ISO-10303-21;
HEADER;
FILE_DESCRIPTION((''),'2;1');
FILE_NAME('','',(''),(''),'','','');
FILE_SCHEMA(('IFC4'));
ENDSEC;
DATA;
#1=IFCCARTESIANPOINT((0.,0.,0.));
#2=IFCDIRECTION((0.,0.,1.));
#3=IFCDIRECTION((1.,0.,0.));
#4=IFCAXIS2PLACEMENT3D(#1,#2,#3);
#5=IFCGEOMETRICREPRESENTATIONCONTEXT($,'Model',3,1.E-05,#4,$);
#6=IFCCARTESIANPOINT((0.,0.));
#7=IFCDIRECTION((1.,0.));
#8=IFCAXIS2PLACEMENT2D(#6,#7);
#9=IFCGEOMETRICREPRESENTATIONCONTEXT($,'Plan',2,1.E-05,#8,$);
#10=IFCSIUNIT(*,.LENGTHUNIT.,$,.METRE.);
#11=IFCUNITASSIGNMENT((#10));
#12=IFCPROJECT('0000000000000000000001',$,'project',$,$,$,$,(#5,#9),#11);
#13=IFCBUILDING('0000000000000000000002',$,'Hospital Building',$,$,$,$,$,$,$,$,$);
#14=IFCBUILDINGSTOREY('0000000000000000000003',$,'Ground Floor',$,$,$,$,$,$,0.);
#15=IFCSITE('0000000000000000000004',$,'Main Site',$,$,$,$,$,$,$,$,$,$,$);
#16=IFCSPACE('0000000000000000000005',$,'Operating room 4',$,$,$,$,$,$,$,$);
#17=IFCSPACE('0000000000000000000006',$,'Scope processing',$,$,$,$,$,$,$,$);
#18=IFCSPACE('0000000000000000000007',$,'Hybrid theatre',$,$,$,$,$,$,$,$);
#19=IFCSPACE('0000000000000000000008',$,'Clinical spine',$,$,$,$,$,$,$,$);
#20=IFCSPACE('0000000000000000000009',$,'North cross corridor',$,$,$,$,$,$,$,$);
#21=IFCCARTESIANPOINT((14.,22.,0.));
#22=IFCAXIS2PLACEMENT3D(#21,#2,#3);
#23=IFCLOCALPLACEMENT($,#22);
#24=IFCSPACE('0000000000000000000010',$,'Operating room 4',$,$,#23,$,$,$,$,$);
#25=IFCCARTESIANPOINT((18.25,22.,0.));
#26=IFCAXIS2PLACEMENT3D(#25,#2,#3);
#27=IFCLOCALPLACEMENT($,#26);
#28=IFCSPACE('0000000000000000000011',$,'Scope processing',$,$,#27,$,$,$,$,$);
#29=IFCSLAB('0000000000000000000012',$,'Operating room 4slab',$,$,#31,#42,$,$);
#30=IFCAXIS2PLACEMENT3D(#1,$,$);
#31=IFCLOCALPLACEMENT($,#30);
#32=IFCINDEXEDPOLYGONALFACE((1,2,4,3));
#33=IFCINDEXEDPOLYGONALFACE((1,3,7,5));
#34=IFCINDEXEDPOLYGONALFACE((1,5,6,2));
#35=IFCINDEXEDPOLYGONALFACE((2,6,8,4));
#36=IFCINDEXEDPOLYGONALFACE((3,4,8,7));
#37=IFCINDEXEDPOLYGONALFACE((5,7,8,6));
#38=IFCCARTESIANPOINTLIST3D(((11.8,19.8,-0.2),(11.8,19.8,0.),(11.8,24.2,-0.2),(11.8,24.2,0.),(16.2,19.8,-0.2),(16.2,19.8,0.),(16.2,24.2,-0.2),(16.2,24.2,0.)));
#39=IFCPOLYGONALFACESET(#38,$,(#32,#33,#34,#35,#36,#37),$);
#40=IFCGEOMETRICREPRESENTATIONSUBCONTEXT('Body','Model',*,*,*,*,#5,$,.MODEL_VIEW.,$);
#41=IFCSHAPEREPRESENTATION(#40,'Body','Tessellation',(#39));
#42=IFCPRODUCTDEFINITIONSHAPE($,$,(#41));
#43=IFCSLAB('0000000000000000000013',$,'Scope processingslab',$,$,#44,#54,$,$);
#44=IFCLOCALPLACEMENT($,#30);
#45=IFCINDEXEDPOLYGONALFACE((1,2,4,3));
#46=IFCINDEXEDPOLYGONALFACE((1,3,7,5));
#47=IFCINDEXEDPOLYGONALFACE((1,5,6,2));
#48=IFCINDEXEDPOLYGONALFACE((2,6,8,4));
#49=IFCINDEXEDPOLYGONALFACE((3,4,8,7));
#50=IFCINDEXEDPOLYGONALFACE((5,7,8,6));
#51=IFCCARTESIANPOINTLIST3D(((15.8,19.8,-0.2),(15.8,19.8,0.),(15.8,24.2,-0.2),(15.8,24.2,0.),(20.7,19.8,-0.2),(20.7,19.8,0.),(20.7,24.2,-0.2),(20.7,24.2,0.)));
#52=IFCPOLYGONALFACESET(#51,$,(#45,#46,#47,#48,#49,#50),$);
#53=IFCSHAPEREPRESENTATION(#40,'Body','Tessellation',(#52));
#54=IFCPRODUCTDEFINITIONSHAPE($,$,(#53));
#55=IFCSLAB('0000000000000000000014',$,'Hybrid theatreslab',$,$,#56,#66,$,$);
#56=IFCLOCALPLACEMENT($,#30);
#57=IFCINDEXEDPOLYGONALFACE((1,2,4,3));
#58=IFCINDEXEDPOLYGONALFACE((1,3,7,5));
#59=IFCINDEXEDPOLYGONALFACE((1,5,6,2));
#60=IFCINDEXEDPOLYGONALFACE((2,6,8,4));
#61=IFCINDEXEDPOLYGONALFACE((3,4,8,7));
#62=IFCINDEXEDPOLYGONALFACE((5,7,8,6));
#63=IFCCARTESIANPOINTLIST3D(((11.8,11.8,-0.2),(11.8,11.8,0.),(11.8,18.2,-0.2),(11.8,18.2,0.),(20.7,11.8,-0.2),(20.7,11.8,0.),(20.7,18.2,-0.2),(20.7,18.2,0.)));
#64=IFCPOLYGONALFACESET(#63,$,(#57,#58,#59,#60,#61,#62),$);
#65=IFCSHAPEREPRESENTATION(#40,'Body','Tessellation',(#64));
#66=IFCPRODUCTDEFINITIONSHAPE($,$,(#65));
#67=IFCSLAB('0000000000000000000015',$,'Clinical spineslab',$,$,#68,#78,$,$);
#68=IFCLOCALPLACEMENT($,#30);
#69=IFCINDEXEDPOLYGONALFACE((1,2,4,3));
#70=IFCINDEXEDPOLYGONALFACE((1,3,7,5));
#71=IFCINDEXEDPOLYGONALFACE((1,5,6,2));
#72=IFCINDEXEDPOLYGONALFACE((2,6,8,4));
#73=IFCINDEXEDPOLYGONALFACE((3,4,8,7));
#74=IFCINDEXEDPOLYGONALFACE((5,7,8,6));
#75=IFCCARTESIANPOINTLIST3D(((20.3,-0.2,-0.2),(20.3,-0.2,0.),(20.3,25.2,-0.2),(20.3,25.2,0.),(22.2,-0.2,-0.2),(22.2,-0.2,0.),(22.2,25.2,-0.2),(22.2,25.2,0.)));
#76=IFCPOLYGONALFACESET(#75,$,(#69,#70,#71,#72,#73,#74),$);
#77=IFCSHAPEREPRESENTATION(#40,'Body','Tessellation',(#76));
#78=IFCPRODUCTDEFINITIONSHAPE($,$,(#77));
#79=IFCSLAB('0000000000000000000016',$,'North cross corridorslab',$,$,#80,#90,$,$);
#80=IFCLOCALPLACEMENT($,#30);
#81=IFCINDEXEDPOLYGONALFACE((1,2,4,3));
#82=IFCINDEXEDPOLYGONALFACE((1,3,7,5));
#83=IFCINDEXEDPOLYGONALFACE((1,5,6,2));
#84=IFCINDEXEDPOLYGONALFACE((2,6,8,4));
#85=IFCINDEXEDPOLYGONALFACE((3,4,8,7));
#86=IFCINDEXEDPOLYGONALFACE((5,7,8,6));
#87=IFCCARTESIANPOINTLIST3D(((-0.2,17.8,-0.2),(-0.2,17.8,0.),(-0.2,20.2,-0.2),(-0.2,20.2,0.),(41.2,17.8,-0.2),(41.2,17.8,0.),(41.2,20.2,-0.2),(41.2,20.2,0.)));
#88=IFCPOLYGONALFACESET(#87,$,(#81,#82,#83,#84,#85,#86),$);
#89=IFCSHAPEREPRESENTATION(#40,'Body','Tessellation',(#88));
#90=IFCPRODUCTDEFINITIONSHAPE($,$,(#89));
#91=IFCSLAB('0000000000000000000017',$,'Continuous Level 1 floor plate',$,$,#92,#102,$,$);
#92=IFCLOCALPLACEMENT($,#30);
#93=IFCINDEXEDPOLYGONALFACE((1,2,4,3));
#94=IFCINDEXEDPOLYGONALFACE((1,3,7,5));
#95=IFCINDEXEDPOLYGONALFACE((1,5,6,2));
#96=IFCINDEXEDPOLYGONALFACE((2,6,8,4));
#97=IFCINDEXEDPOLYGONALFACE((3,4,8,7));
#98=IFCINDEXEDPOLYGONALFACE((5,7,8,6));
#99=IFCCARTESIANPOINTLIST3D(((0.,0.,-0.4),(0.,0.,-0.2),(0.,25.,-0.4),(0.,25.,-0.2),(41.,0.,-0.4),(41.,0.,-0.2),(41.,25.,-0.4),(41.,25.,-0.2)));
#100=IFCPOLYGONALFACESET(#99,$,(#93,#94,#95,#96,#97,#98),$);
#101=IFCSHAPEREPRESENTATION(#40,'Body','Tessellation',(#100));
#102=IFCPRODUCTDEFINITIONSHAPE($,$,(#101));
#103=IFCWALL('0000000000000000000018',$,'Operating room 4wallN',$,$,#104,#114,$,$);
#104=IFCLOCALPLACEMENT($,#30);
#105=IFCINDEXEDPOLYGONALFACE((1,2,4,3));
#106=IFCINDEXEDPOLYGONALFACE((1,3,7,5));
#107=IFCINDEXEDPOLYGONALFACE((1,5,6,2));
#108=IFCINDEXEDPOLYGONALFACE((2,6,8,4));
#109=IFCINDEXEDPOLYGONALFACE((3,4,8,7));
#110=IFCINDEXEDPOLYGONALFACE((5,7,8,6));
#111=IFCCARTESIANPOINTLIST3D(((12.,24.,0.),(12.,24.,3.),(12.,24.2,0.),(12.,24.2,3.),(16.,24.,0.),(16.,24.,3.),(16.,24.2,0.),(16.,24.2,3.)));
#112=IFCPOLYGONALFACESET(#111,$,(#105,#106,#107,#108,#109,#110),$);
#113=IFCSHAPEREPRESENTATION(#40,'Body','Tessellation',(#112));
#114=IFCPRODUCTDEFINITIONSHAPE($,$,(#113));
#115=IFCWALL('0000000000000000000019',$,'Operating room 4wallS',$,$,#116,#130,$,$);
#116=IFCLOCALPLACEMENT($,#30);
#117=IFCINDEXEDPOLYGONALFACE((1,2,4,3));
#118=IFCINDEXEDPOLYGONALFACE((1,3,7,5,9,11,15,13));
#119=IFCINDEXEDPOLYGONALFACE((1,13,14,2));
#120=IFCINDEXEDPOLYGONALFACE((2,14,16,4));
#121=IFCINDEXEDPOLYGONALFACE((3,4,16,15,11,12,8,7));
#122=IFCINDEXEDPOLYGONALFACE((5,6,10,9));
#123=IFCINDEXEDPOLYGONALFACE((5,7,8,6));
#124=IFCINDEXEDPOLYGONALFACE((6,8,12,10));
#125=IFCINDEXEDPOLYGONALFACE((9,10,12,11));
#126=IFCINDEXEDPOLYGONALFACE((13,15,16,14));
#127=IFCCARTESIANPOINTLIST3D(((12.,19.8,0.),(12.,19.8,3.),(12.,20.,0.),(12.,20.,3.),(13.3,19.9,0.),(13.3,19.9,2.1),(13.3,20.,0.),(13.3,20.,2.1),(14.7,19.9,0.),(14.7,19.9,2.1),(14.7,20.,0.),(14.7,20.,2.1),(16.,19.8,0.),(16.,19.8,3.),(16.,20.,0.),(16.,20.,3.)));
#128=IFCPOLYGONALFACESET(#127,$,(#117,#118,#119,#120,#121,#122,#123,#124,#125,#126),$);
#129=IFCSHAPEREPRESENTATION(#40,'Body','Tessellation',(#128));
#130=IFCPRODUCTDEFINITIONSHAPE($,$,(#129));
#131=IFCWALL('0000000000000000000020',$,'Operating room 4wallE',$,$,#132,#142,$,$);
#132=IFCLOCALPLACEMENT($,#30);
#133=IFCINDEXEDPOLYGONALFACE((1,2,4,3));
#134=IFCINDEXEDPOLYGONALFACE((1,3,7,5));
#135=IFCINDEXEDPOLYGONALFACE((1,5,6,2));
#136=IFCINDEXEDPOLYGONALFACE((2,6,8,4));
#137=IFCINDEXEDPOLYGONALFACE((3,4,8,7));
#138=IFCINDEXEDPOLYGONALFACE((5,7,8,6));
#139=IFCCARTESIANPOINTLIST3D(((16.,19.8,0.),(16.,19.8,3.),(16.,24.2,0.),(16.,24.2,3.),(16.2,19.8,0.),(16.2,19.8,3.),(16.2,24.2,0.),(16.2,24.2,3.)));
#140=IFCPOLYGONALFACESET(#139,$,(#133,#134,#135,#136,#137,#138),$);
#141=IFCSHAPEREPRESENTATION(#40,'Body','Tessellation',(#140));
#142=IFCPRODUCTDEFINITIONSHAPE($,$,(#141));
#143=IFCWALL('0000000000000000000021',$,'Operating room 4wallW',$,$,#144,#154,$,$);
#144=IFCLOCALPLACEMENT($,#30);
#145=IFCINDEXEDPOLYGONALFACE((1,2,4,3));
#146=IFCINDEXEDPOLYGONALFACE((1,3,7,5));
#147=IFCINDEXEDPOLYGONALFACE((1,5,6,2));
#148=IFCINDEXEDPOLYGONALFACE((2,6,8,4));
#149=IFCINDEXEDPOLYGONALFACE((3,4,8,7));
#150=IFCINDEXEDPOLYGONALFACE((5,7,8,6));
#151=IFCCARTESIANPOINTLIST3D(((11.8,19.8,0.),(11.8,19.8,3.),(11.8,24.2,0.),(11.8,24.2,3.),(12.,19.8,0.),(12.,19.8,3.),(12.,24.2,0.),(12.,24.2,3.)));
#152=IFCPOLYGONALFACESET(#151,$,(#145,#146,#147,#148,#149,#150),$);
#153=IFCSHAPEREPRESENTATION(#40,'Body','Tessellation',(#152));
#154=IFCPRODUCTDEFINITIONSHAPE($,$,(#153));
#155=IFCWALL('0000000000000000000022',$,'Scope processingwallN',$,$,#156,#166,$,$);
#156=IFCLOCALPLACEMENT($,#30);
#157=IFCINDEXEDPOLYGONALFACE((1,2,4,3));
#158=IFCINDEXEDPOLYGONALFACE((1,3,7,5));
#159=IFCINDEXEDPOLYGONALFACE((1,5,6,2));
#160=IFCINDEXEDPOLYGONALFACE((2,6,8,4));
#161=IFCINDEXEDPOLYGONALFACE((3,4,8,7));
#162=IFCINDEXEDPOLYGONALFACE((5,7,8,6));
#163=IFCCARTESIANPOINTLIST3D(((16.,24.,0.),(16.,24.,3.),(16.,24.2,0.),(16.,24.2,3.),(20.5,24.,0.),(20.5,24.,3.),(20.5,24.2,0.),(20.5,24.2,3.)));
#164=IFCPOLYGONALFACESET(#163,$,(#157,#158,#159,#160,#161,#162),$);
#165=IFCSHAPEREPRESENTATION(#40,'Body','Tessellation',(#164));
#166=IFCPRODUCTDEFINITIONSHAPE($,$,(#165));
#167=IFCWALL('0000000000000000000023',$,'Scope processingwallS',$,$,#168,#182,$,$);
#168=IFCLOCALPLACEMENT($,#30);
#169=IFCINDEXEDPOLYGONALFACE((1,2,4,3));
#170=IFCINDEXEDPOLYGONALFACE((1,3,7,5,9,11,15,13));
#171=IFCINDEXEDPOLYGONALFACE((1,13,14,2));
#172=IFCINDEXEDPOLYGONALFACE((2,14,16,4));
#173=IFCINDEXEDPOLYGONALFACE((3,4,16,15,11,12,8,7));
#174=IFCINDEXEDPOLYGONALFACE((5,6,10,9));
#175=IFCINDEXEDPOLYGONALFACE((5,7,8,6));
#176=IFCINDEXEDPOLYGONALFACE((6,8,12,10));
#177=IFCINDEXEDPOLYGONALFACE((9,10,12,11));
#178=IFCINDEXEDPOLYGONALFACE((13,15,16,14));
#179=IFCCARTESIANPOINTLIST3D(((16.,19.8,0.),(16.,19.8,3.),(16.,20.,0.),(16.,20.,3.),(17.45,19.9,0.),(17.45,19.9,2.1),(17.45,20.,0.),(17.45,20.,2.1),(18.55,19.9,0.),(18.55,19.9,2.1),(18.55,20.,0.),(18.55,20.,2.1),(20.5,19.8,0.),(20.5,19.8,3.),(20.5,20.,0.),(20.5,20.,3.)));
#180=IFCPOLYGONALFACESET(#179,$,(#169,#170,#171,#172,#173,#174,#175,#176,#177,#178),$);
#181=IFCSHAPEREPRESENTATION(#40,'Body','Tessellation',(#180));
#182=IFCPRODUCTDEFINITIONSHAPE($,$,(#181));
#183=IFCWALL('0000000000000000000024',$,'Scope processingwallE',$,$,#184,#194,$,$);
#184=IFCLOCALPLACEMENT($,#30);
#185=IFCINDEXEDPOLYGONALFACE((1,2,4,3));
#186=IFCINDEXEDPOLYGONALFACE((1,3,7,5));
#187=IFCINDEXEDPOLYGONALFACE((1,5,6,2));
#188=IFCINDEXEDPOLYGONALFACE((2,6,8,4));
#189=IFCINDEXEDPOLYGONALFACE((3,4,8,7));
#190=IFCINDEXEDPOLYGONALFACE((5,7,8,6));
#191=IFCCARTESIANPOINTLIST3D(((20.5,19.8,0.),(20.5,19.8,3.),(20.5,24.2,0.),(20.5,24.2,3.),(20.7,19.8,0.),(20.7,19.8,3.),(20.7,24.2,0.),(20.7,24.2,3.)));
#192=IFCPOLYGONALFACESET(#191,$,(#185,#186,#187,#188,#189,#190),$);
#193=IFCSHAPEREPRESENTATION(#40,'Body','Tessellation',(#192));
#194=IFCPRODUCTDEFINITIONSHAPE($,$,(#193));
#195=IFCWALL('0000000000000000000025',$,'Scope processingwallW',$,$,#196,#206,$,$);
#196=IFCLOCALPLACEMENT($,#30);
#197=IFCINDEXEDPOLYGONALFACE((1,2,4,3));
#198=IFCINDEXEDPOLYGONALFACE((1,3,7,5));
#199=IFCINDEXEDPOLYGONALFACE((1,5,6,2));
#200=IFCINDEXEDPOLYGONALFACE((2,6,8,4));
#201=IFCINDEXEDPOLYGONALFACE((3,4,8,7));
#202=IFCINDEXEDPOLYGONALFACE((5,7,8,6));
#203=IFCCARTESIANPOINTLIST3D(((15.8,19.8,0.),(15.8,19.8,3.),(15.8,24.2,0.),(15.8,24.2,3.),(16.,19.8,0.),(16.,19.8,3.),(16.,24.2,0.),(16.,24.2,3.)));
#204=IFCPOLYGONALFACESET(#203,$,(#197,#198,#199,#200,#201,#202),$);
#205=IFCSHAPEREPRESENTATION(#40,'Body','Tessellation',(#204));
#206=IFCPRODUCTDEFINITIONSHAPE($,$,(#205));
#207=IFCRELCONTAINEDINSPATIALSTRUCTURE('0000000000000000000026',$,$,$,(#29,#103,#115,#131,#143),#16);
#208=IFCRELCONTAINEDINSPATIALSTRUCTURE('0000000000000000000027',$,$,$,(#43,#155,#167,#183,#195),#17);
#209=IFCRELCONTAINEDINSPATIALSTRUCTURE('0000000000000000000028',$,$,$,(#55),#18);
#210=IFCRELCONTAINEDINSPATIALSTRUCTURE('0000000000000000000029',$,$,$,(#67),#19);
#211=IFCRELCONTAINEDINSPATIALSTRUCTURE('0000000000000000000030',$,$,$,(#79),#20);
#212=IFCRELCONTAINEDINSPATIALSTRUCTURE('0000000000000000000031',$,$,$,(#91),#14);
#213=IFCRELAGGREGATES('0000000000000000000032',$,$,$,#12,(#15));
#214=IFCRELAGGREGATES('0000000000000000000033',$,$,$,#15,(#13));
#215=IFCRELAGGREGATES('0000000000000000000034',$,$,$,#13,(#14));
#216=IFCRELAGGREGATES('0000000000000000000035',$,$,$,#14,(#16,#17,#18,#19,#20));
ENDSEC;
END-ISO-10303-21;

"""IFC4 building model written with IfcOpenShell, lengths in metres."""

from ifc_helpers import new_model, si_unit, frame, origin_with_axes, origin_2d_with_axis, place, context, subcontext, project, spatial, indexed_curve, rectangle, outline, extrude, element, save


model = new_model("IFC4")

# Units and contexts
model_context = context("Model", 3, precision=1e-05, world=origin_with_axes())
plan_context = context("Plan", 2, precision=1e-05, world=origin_2d_with_axis())
body_context = subcontext(model_context, "Body", "Model", "MODEL_VIEW")
ifc_project = project(units=[si_unit("LENGTHUNIT", "METRE")], contexts=[model_context, plan_context])

# Site, building, storey, space
site = spatial("IfcSite", under=ifc_project, Name="Main Site")
building = spatial("IfcBuilding", under=site, Name="Hospital Building")
storey = spatial("IfcBuildingStorey", under=building, Name="Ground Floor", Elevation=0.0)
space_1 = spatial("IfcSpace", under=storey, Name="Operating room 4")

# Slab
slab_1_placement = place(None, frame((14.0, 22.0, -0.2), z_axis=(0.0, 0.0, 1.0), x_axis=(1.0, 0.0, 0.0)))
element("IfcSlab", 1, at=slab_1_placement, inside=space_1, Name="Operating room 4slab", context=body_context, shape_type="SweptSolid", body=[
    extrude(rectangle(XDim=4.4, YDim=4.4), origin_with_axes(), (0.0, 0.0, 1.0), 0.2),
])

# Shared definitions
space_2 = spatial("IfcSpace", under=storey, Name="Scope processing")

# Slab
slab_2_placement = place(None, frame((18.25, 22.0, -0.2), z_axis=(0.0, 0.0, 1.0), x_axis=(1.0, 0.0, 0.0)))
element("IfcSlab", 2, at=slab_2_placement, inside=space_2, Name="Scope processingslab", context=body_context, shape_type="SweptSolid", body=[
    extrude(rectangle(XDim=4.9, YDim=4.4), origin_with_axes(), (0.0, 0.0, 1.0), 0.2),
])

# Shared definitions
space_3 = spatial("IfcSpace", under=storey, Name="Hybrid theatre")

# Slab
slab_3_placement = place(None, frame((16.25, 15.0, -0.2), z_axis=(0.0, 0.0, 1.0), x_axis=(1.0, 0.0, 0.0)))
element("IfcSlab", 3, at=slab_3_placement, inside=space_3, Name="Hybrid theatreslab", context=body_context, shape_type="SweptSolid", body=[
    extrude(rectangle(XDim=8.9, YDim=6.4), origin_with_axes(), (0.0, 0.0, 1.0), 0.2),
])

# Shared definitions
space_4 = spatial("IfcSpace", under=storey, Name="Clinical spine")

# Slab
slab_4_placement = place(None, frame((21.25, 12.5, -0.2), z_axis=(0.0, 0.0, 1.0), x_axis=(1.0, 0.0, 0.0)))
element("IfcSlab", 4, at=slab_4_placement, inside=space_4, Name="Clinical spineslab", context=body_context, shape_type="SweptSolid", body=[
    extrude(rectangle(XDim=1.9, YDim=25.4), origin_with_axes(), (0.0, 0.0, 1.0), 0.2),
])

# Shared definitions
space_5 = spatial("IfcSpace", under=storey, Name="North cross corridor")

# Slabs
slab_5_placement = place(None, frame((20.5, 19.0, -0.2), z_axis=(0.0, 0.0, 1.0), x_axis=(1.0, 0.0, 0.0)))
element("IfcSlab", 5, at=slab_5_placement, inside=space_5, Name="North cross corridorslab", context=body_context, shape_type="SweptSolid", body=[
    extrude(rectangle(XDim=41.4, YDim=2.4), origin_with_axes(), (0.0, 0.0, 1.0), 0.2),
])
slab_6_placement = place(None, frame((20.5, 12.5, -0.4), z_axis=(0.0, 0.0, 1.0), x_axis=(1.0, 0.0, 0.0)))
element("IfcSlab", 6, at=slab_6_placement, inside=storey, Name="Continuous Level 1 floor plate", context=body_context, shape_type="SweptSolid", body=[
    extrude(rectangle(XDim=41.0, YDim=25.0), origin_with_axes(), (0.0, 0.0, 1.0), 0.2),
])

# Walls
wall_1_placement = place(None, frame((12.0, 24.0, 0.0), z_axis=(0.0, 0.0, 1.0), x_axis=(1.0, 0.0, 0.0)))
element("IfcWall", 7, at=wall_1_placement, inside=space_1, Name="Operating room 4wallN", context=body_context, shape_type="SweptSolid", body=[
    extrude(outline(indexed_curve([(0.0, 0.0), (0.0, 0.2), (4.0, 0.2), (4.0, 0.0), (0.0, 0.0)], self_intersect=False)), origin_with_axes(), (0.0, 0.0, 1.0), 3.0),
])
wall_2_placement = place(None, frame((12.0, 19.8, 0.0), z_axis=(0.0, 0.0, 1.0), x_axis=(1.0, 0.0, 0.0)))
wall_2 = element("IfcWall", 8, at=wall_2_placement, inside=space_1, Name="Operating room 4wallS", context=body_context, shape_type="SweptSolid", body=[
    extrude(outline(indexed_curve([(0.0, 0.0), (0.0, 0.2), (4.0, 0.2), (4.0, 0.0), (0.0, 0.0)], self_intersect=False)), origin_with_axes(), (0.0, 0.0, 1.0), 3.0),
])

# Shared definitions
space_6_placement = place(None, frame((14.0, 22.0, 0.0), z_axis=(0.0, 0.0, 1.0), x_axis=(1.0, 0.0, 0.0)))
space_6 = spatial("IfcSpace", at=space_6_placement, Name="Operating room 4")

# Opening
opening_1_placement = place(wall_2_placement, frame((1.3, 0.1, 0.0), z_axis=(0.0, 0.0, 1.0), x_axis=(1.0, 0.0, 0.0)))
element("IfcOpeningElement", 9, at=opening_1_placement, inside=space_6, cuts=wall_2, context=body_context, shape_type="SweptSolid", body=[
    extrude(outline(indexed_curve([(0.0, 0.0), (0.0, 0.4), (1.4, 0.4), (1.4, 0.0), (0.0, 0.0)], self_intersect=False)), origin_with_axes(), (0.0, 0.0, 1.0), 2.1),
])

# Walls
for number, where, z_axis, x_axis, name in (
    (10, (16.2, 19.8, 0.0), (0.0, 0.0, 1.0), (0.0, 1.0, 0.0), "Operating room 4wallE"),
    (11, (12.0, 19.8, 0.0), (0.0, 0.0, 1.0), (0.0, 1.0, 0.0), "Operating room 4wallW"),
):
    element("IfcWall", number, at=place(None, frame(where, z_axis=z_axis, x_axis=x_axis)), inside=space_1, Name=name, context=body_context, shape_type="SweptSolid", body=[
        extrude(outline(indexed_curve([(0.0, 0.0), (0.0, 0.2), (4.4, 0.2), (4.4, 0.0), (0.0, 0.0)], self_intersect=False)), origin_with_axes(), (0.0, 0.0, 1.0), 3.0),
    ])
wall_3_placement = place(None, frame((16.0, 24.0, 0.0), z_axis=(0.0, 0.0, 1.0), x_axis=(1.0, 0.0, 0.0)))
element("IfcWall", 12, at=wall_3_placement, inside=space_2, Name="Scope processingwallN", context=body_context, shape_type="SweptSolid", body=[
    extrude(outline(indexed_curve([(0.0, 0.0), (0.0, 0.2), (4.5, 0.2), (4.5, 0.0), (0.0, 0.0)], self_intersect=False)), origin_with_axes(), (0.0, 0.0, 1.0), 3.0),
])

# Wall
wall_4_placement = place(None, frame((16.0, 19.8, 0.0), z_axis=(0.0, 0.0, 1.0), x_axis=(1.0, 0.0, 0.0)))
wall_4 = element("IfcWall", 13, at=wall_4_placement, inside=space_2, Name="Scope processingwallS", context=body_context, shape_type="SweptSolid", body=[
    extrude(outline(indexed_curve([(0.0, 0.0), (0.0, 0.2), (4.5, 0.2), (4.5, 0.0), (0.0, 0.0)], self_intersect=False)), origin_with_axes(), (0.0, 0.0, 1.0), 3.0),
])

# Shared definitions
space_7_placement = place(None, frame((18.25, 22.0, 0.0), z_axis=(0.0, 0.0, 1.0), x_axis=(1.0, 0.0, 0.0)))
space_7 = spatial("IfcSpace", at=space_7_placement, Name="Scope processing")

# Opening
opening_2_placement = place(wall_4_placement, frame((1.45, 0.1, 0.0), z_axis=(0.0, 0.0, 1.0), x_axis=(1.0, 0.0, 0.0)))
element("IfcOpeningElement", 14, at=opening_2_placement, inside=space_7, cuts=wall_4, context=body_context, shape_type="SweptSolid", body=[
    extrude(outline(indexed_curve([(0.0, 0.0), (0.0, 0.4), (1.1, 0.4), (1.1, 0.0), (0.0, 0.0)], self_intersect=False)), origin_with_axes(), (0.0, 0.0, 1.0), 2.1),
])

# Walls
for number, where, z_axis, x_axis, name in (
    (15, (20.7, 19.8, 0.0), (0.0, 0.0, 1.0), (0.0, 1.0, 0.0), "Scope processingwallE"),
    (16, (16.0, 19.8, 0.0), (0.0, 0.0, 1.0), (0.0, 1.0, 0.0), "Scope processingwallW"),
):
    element("IfcWall", number, at=place(None, frame(where, z_axis=z_axis, x_axis=x_axis)), inside=space_2, Name=name, context=body_context, shape_type="SweptSolid", body=[
        extrude(outline(indexed_curve([(0.0, 0.0), (0.0, 0.2), (4.4, 0.2), (4.4, 0.0), (0.0, 0.0)], self_intersect=False)), origin_with_axes(), (0.0, 0.0, 1.0), 3.0),
    ])

save(model, "model.ifc")
